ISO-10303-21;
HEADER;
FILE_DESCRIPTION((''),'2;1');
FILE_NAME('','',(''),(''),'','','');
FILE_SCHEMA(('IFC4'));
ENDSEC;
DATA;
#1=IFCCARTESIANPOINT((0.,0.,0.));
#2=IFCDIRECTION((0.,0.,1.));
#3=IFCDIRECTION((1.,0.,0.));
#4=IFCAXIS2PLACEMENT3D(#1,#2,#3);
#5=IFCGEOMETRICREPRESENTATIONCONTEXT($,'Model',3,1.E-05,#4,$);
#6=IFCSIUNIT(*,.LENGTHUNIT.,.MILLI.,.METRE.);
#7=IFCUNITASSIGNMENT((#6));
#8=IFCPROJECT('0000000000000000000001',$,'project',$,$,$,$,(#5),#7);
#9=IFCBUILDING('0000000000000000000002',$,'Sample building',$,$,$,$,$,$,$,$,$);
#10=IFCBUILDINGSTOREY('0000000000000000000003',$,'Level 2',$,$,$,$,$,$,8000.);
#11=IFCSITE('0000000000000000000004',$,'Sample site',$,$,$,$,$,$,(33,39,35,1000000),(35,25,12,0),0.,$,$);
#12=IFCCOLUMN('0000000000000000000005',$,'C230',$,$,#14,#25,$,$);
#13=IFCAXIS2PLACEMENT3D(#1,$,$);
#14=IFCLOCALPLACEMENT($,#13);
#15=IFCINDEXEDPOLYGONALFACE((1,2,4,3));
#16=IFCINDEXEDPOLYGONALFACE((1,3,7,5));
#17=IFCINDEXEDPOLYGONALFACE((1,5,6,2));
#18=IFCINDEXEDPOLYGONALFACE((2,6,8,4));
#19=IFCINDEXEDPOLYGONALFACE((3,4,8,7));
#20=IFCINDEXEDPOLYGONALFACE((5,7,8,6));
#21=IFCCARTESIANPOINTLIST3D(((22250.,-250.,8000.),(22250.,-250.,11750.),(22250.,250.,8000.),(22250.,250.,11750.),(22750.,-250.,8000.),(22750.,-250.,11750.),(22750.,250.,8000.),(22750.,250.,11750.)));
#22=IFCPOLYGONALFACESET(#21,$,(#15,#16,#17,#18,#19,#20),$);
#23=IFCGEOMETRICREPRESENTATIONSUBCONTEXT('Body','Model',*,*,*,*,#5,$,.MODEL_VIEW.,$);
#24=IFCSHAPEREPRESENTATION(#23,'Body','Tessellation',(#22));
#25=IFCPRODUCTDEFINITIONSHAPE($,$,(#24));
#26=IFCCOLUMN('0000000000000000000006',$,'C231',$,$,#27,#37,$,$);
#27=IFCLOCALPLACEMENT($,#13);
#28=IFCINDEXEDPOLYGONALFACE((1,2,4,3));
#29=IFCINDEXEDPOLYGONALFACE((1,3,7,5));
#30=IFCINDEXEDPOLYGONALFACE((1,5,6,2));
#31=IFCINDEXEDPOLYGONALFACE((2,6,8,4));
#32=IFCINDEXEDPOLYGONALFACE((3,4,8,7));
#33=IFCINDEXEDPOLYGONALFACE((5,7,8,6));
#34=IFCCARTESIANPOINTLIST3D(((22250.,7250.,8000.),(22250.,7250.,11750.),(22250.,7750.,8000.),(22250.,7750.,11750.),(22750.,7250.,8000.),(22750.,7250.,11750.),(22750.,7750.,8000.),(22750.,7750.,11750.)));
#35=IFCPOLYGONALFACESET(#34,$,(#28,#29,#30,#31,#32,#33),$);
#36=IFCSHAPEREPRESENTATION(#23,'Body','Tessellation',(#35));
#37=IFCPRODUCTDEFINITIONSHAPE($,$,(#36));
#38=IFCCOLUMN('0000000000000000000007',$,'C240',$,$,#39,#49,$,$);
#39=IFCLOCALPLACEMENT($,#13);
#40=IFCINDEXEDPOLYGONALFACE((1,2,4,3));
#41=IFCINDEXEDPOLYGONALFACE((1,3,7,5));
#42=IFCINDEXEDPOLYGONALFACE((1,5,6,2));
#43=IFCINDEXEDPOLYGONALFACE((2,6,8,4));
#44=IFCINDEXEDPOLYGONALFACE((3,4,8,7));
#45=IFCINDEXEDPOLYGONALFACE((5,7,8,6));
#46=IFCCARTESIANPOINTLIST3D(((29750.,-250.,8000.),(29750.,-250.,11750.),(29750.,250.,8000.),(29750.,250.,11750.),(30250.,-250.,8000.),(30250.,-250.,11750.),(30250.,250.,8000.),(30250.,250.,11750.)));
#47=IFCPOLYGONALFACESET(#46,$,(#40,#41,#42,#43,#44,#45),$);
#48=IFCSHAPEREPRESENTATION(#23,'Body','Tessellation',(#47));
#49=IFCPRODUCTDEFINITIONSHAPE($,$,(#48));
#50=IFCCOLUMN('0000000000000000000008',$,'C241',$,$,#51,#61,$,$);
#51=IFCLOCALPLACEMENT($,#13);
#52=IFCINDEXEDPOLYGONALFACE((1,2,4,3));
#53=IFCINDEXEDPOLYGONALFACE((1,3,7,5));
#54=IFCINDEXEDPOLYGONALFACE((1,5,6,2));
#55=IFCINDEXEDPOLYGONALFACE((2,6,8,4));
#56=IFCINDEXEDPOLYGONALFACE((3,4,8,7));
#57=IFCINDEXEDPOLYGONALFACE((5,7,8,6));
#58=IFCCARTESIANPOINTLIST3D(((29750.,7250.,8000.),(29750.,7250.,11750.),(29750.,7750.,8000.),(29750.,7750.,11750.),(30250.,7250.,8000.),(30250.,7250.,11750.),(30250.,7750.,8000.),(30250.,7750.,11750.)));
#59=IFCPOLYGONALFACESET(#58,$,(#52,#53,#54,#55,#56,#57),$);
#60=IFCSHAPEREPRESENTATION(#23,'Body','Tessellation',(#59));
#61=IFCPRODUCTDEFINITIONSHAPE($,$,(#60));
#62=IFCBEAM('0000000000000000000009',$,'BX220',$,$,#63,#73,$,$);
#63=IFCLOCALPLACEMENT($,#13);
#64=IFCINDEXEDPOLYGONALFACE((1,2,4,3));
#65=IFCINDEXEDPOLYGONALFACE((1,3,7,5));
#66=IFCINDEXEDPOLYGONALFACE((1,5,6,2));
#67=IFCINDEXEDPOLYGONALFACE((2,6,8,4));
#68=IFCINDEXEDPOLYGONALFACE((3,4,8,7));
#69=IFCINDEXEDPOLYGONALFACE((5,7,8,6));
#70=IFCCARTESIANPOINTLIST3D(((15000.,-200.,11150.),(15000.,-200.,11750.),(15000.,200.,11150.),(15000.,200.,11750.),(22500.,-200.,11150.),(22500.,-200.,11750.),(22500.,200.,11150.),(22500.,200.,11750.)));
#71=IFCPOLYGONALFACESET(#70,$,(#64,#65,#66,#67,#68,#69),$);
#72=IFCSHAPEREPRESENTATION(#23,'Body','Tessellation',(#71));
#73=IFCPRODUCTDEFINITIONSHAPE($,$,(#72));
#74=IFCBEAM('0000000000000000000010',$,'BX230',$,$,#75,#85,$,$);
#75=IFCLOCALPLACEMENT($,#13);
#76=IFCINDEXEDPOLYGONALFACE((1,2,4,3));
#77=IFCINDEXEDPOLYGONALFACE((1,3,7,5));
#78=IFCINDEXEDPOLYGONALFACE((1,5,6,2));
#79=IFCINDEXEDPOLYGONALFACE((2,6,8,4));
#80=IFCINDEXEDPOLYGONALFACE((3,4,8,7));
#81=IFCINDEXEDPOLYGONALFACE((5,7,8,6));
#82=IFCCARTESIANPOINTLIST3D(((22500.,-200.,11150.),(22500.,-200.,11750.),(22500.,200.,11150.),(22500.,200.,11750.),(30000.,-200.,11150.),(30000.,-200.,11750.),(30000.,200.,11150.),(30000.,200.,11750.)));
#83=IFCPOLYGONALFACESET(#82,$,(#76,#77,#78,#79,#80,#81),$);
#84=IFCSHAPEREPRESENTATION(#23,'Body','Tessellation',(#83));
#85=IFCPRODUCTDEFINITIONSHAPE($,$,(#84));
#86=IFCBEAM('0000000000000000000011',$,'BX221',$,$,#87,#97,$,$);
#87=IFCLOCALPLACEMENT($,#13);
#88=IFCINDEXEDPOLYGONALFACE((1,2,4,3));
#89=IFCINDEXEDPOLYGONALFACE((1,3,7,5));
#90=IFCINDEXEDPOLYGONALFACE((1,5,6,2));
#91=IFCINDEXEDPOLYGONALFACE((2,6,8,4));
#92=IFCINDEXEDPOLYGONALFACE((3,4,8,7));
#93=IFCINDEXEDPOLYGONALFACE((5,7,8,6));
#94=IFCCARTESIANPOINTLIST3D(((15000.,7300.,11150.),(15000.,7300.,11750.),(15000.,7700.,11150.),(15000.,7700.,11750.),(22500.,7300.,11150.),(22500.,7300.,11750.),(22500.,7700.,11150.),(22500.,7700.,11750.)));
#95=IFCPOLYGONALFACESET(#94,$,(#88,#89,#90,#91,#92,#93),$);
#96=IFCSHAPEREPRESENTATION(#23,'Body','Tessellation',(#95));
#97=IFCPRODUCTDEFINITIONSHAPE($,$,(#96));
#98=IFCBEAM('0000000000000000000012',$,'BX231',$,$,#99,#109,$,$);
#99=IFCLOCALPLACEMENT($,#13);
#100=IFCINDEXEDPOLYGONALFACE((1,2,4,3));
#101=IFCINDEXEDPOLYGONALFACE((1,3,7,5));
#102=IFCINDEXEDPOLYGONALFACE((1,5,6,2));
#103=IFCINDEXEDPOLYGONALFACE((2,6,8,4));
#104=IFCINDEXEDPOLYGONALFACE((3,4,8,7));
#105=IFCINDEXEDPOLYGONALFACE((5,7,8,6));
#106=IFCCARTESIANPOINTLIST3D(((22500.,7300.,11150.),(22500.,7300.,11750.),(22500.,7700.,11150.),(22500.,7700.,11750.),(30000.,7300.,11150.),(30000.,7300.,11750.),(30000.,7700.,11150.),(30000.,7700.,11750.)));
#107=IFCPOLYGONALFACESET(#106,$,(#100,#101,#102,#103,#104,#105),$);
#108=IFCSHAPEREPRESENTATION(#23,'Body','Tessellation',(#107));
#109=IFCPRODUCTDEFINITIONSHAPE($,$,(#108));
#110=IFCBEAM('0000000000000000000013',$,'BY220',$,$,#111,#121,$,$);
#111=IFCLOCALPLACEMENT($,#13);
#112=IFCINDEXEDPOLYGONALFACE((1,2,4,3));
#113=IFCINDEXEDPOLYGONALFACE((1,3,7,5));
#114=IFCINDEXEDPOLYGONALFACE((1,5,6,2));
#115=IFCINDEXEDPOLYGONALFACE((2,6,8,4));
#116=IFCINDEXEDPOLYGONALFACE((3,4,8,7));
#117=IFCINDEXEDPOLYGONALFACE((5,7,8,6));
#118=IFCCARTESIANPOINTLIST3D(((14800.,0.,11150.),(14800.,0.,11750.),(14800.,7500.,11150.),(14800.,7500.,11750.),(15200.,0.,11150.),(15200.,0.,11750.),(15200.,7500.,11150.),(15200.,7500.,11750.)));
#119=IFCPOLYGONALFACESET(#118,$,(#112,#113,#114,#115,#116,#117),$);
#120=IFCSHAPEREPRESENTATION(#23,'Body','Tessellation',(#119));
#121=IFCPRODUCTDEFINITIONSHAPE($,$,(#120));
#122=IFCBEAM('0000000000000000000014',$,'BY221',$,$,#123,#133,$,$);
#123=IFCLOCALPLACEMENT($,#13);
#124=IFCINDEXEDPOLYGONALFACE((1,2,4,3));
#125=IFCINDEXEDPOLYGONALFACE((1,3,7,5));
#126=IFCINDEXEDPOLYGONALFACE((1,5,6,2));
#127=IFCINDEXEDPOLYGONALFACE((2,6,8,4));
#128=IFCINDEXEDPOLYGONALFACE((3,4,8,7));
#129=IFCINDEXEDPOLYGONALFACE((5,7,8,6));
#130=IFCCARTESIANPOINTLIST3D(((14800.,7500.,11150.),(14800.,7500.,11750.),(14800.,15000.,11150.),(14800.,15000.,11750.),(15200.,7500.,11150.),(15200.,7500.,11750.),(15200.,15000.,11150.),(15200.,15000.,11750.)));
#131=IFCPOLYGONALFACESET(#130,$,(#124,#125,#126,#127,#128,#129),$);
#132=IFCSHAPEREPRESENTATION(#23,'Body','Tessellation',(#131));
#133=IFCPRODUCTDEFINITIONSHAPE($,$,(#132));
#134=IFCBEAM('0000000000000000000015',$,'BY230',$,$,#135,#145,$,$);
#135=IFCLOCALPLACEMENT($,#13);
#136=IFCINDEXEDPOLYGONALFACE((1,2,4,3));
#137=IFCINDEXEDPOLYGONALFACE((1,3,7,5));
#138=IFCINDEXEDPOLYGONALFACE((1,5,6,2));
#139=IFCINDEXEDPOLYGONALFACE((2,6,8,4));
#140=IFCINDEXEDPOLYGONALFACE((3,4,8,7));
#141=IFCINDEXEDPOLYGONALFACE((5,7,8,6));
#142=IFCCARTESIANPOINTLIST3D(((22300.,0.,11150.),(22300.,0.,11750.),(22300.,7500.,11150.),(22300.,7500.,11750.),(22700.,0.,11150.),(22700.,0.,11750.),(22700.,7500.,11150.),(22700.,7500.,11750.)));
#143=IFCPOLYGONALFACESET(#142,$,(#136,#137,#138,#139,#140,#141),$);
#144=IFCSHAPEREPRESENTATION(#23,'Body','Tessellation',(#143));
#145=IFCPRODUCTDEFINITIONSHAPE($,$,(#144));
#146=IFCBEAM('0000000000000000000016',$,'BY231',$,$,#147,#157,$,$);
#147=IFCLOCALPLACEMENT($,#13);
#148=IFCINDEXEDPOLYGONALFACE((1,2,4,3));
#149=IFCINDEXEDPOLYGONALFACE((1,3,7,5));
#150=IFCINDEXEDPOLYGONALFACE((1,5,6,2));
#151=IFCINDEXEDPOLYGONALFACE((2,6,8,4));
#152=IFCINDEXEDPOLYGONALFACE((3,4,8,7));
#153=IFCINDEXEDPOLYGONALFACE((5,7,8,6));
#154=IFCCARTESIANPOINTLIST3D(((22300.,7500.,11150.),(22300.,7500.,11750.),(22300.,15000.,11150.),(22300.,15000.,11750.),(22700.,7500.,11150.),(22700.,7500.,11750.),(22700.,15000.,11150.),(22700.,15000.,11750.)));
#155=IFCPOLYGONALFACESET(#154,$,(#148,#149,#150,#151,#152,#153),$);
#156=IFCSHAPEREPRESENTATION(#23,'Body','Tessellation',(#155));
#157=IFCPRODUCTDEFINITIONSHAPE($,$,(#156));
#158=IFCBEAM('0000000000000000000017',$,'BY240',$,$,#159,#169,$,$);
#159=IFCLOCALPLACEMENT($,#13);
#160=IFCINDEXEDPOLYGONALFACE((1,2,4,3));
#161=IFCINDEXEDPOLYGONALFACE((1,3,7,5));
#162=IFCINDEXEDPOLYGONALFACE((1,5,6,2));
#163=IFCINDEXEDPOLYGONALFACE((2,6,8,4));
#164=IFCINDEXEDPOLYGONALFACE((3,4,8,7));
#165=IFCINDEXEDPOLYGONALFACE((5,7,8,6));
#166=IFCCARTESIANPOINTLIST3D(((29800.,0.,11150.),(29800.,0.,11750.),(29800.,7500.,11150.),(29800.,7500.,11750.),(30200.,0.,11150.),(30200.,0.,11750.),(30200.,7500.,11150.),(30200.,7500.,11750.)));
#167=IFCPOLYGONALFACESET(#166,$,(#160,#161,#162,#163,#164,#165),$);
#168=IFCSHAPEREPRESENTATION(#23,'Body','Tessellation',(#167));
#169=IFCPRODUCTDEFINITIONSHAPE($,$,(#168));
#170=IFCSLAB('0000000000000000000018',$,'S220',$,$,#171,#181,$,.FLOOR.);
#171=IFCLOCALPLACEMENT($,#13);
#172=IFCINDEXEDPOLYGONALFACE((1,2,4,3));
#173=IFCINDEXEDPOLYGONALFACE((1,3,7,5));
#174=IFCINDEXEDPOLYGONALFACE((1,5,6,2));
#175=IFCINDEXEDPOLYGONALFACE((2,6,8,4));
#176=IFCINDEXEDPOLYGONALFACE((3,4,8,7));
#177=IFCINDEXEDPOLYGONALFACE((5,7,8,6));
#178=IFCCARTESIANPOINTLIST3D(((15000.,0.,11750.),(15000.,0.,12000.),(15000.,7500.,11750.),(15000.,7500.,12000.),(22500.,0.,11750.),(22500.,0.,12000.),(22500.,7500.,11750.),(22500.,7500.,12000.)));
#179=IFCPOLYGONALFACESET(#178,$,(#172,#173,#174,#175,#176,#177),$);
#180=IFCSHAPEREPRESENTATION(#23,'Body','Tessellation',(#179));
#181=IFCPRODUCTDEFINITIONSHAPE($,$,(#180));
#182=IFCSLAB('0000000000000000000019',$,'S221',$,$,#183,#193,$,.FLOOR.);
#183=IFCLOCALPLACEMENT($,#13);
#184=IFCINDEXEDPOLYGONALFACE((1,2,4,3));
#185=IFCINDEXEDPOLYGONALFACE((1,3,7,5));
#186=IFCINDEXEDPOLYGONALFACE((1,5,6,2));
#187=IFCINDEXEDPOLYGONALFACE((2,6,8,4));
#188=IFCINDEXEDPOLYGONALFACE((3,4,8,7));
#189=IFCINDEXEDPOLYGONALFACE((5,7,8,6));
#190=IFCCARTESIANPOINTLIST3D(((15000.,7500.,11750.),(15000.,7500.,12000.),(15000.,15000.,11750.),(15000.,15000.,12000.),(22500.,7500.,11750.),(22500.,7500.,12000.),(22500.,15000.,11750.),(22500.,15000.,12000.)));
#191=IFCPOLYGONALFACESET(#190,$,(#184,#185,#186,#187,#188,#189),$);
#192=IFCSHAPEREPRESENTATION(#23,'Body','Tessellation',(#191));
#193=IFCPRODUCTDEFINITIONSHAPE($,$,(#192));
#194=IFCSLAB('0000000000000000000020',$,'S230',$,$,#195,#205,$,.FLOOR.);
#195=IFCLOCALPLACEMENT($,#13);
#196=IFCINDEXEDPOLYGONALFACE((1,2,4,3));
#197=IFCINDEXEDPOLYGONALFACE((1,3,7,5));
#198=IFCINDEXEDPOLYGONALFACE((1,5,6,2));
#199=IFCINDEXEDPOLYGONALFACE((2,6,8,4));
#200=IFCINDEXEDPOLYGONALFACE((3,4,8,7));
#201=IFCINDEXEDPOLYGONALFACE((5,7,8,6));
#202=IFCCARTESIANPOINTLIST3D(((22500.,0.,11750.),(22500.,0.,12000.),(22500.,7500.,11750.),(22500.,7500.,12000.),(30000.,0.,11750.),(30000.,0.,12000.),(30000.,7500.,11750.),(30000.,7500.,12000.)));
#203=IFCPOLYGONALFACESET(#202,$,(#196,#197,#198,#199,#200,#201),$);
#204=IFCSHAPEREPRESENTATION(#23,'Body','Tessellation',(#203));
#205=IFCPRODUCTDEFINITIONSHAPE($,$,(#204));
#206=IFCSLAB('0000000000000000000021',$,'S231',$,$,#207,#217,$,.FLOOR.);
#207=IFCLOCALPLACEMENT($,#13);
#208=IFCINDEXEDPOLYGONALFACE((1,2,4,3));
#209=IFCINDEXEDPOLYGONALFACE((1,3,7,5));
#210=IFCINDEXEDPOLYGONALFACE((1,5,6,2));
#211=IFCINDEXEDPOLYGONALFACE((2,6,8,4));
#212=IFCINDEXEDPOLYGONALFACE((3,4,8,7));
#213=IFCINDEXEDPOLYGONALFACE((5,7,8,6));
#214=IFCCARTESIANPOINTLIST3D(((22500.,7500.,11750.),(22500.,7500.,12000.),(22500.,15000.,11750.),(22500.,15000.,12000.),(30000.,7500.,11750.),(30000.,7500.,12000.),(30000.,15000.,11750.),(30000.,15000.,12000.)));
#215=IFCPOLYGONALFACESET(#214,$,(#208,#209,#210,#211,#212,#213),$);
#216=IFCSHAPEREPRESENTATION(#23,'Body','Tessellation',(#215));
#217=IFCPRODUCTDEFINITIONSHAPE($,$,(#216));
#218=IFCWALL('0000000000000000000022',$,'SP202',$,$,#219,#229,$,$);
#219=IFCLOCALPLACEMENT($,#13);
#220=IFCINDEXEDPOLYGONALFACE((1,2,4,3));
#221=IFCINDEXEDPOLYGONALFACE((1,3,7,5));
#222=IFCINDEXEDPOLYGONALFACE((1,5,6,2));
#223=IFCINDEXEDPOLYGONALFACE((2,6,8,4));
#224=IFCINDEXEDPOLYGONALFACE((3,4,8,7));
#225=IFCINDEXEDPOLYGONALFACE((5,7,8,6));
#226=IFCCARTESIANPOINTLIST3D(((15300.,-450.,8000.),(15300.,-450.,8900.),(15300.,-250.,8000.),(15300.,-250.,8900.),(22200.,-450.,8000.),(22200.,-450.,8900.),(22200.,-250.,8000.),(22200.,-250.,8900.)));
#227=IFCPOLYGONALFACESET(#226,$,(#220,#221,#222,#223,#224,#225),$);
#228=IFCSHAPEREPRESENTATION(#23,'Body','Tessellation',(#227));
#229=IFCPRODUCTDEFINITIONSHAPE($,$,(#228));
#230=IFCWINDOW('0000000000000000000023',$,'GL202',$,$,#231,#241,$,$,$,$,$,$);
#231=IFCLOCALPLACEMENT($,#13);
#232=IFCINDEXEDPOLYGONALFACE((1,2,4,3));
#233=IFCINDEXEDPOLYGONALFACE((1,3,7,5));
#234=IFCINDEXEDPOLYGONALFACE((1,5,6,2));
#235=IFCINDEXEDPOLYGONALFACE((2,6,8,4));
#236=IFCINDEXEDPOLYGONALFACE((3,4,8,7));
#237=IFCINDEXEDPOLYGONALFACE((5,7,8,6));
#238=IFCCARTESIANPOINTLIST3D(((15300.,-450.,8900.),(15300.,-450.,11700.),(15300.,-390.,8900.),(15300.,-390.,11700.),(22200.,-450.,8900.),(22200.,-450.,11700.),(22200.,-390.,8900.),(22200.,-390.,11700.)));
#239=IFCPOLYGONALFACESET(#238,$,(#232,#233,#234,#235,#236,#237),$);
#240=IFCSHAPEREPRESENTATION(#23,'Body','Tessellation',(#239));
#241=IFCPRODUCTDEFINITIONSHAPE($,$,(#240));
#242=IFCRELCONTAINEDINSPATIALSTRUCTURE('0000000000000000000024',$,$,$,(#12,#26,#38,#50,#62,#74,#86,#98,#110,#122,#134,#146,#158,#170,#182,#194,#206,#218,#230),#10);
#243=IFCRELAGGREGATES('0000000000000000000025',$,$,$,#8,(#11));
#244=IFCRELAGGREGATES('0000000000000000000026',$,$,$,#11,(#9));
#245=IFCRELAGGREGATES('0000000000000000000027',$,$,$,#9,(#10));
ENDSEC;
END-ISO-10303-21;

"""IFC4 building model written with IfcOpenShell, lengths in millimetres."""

from ifc_helpers import new_model, si_unit, frame, origin_with_axes, place, context, subcontext, project, spatial, indexed_curve, outline, extrude, element, save


model = new_model("IFC4")

# Units and contexts
model_context = context("Model", 3, precision=1e-05, world=origin_with_axes())
body_context = subcontext(model_context, "Body", "Model", "MODEL_VIEW")
ifc_project = project(units=[si_unit("LENGTHUNIT", "METRE", prefix="MILLI")], contexts=[model_context])

# Site, building, storey
site = spatial("IfcSite", under=ifc_project, Name="Sample site", RefLatitude=(33, 39, 35, 1000000), RefLongitude=(35, 25, 12, 0), RefElevation=0.0)
building = spatial("IfcBuilding", under=site, Name="Sample building")
storey = spatial("IfcBuildingStorey", under=building, Name="Level 2", Elevation=8000.0)

# Columns
for number, where, z_axis, x_axis, name in (
    (1, (22250.0, -250.0, 8000.0), (0.0, 0.0, 1.0), (1.0, 0.0, 0.0), "C230"),
    (2, (22250.0, 7250.0, 8000.0), (0.0, 0.0, 1.0), (1.0, 0.0, 0.0), "C231"),
    (3, (29750.0, -250.0, 8000.0), (0.0, 0.0, 1.0), (1.0, 0.0, 0.0), "C240"),
    (4, (29750.0, 7250.0, 8000.0), (0.0, 0.0, 1.0), (1.0, 0.0, 0.0), "C241"),
):
    element("IfcColumn", number, at=place(None, frame(where, z_axis=z_axis, x_axis=x_axis)), inside=storey, Name=name, context=body_context, shape_type="SweptSolid", body=[
        extrude(outline(indexed_curve([(0.0, 0.0), (0.0, 500.0), (500.0, 500.0), (500.0, 0.0), (0.0, 0.0)], self_intersect=False)), origin_with_axes(), (0.0, 0.0, 1.0), 3750.0),
    ])

# Beams
for number, where, z_axis, x_axis, name in (
    (5, (15000.0, -200.0, 11150.0), (0.0, 0.0, 1.0), (1.0, 0.0, 0.0), "BX220"),
    (6, (22500.0, -200.0, 11150.0), (0.0, 0.0, 1.0), (1.0, 0.0, 0.0), "BX230"),
    (7, (15000.0, 7300.0, 11150.0), (0.0, 0.0, 1.0), (1.0, 0.0, 0.0), "BX221"),
    (8, (22500.0, 7300.0, 11150.0), (0.0, 0.0, 1.0), (1.0, 0.0, 0.0), "BX231"),
    (9, (15200.0, 0.0, 11150.0), (0.0, 0.0, 1.0), (0.0, 1.0, 0.0), "BY220"),
    (10, (15200.0, 7500.0, 11150.0), (0.0, 0.0, 1.0), (0.0, 1.0, 0.0), "BY221"),
    (11, (22700.0, 0.0, 11150.0), (0.0, 0.0, 1.0), (0.0, 1.0, 0.0), "BY230"),
    (12, (22700.0, 7500.0, 11150.0), (0.0, 0.0, 1.0), (0.0, 1.0, 0.0), "BY231"),
    (13, (30200.0, 0.0, 11150.0), (0.0, 0.0, 1.0), (0.0, 1.0, 0.0), "BY240"),
):
    element("IfcBeam", number, at=place(None, frame(where, z_axis=z_axis, x_axis=x_axis)), inside=storey, Name=name, context=body_context, shape_type="SweptSolid", body=[
        extrude(outline(indexed_curve([(0.0, 0.0), (0.0, 400.0), (7500.0, 400.0), (7500.0, 0.0), (0.0, 0.0)], self_intersect=False)), origin_with_axes(), (0.0, 0.0, 1.0), 600.0),
    ])

# Slabs
for number, where, z_axis, x_axis, name in (
    (14, (15000.0, 0.0, 11750.0), (0.0, 0.0, 1.0), (1.0, 0.0, 0.0), "S220"),
    (15, (15000.0, 7500.0, 11750.0), (0.0, 0.0, 1.0), (1.0, 0.0, 0.0), "S221"),
    (16, (22500.0, 0.0, 11750.0), (0.0, 0.0, 1.0), (1.0, 0.0, 0.0), "S230"),
    (17, (22500.0, 7500.0, 11750.0), (0.0, 0.0, 1.0), (1.0, 0.0, 0.0), "S231"),
):
    element("IfcSlab", number, at=place(None, frame(where, z_axis=z_axis, x_axis=x_axis)), inside=storey, Name=name, PredefinedType="FLOOR", context=body_context, shape_type="SweptSolid", body=[
        extrude(outline(indexed_curve([(0.0, 0.0), (0.0, 7500.0), (7500.0, 7500.0), (7500.0, 0.0), (0.0, 0.0)], self_intersect=False)), origin_with_axes(), (0.0, 0.0, 1.0), 250.0),
    ])

# Wall
wall_1_placement = place(None, frame((15300.0, -450.0, 8000.0), z_axis=(0.0, 0.0, 1.0), x_axis=(1.0, 0.0, 0.0)))
element("IfcWall", 18, at=wall_1_placement, inside=storey, Name="SP202", context=body_context, shape_type="SweptSolid", body=[
    extrude(outline(indexed_curve([(0.0, 0.0), (0.0, 200.0), (6900.0, 200.0), (6900.0, 0.0), (0.0, 0.0)], self_intersect=False)), origin_with_axes(), (0.0, 0.0, 1.0), 900.0),
])

# Window
window_1_placement = place(None, frame((15300.0, -450.0, 8900.0), z_axis=(0.0, 0.0, 1.0), x_axis=(1.0, 0.0, 0.0)))
element("IfcWindow", 19, at=window_1_placement, inside=storey, Name="GL202", context=body_context, shape_type="SweptSolid", body=[
    extrude(outline(indexed_curve([(0.0, 0.0), (0.0, 60.0), (6900.0, 60.0), (6900.0, 0.0), (0.0, 0.0)], self_intersect=False)), origin_with_axes(), (0.0, 0.0, 1.0), 2800.0),
])

save(model, "model.ifc")
